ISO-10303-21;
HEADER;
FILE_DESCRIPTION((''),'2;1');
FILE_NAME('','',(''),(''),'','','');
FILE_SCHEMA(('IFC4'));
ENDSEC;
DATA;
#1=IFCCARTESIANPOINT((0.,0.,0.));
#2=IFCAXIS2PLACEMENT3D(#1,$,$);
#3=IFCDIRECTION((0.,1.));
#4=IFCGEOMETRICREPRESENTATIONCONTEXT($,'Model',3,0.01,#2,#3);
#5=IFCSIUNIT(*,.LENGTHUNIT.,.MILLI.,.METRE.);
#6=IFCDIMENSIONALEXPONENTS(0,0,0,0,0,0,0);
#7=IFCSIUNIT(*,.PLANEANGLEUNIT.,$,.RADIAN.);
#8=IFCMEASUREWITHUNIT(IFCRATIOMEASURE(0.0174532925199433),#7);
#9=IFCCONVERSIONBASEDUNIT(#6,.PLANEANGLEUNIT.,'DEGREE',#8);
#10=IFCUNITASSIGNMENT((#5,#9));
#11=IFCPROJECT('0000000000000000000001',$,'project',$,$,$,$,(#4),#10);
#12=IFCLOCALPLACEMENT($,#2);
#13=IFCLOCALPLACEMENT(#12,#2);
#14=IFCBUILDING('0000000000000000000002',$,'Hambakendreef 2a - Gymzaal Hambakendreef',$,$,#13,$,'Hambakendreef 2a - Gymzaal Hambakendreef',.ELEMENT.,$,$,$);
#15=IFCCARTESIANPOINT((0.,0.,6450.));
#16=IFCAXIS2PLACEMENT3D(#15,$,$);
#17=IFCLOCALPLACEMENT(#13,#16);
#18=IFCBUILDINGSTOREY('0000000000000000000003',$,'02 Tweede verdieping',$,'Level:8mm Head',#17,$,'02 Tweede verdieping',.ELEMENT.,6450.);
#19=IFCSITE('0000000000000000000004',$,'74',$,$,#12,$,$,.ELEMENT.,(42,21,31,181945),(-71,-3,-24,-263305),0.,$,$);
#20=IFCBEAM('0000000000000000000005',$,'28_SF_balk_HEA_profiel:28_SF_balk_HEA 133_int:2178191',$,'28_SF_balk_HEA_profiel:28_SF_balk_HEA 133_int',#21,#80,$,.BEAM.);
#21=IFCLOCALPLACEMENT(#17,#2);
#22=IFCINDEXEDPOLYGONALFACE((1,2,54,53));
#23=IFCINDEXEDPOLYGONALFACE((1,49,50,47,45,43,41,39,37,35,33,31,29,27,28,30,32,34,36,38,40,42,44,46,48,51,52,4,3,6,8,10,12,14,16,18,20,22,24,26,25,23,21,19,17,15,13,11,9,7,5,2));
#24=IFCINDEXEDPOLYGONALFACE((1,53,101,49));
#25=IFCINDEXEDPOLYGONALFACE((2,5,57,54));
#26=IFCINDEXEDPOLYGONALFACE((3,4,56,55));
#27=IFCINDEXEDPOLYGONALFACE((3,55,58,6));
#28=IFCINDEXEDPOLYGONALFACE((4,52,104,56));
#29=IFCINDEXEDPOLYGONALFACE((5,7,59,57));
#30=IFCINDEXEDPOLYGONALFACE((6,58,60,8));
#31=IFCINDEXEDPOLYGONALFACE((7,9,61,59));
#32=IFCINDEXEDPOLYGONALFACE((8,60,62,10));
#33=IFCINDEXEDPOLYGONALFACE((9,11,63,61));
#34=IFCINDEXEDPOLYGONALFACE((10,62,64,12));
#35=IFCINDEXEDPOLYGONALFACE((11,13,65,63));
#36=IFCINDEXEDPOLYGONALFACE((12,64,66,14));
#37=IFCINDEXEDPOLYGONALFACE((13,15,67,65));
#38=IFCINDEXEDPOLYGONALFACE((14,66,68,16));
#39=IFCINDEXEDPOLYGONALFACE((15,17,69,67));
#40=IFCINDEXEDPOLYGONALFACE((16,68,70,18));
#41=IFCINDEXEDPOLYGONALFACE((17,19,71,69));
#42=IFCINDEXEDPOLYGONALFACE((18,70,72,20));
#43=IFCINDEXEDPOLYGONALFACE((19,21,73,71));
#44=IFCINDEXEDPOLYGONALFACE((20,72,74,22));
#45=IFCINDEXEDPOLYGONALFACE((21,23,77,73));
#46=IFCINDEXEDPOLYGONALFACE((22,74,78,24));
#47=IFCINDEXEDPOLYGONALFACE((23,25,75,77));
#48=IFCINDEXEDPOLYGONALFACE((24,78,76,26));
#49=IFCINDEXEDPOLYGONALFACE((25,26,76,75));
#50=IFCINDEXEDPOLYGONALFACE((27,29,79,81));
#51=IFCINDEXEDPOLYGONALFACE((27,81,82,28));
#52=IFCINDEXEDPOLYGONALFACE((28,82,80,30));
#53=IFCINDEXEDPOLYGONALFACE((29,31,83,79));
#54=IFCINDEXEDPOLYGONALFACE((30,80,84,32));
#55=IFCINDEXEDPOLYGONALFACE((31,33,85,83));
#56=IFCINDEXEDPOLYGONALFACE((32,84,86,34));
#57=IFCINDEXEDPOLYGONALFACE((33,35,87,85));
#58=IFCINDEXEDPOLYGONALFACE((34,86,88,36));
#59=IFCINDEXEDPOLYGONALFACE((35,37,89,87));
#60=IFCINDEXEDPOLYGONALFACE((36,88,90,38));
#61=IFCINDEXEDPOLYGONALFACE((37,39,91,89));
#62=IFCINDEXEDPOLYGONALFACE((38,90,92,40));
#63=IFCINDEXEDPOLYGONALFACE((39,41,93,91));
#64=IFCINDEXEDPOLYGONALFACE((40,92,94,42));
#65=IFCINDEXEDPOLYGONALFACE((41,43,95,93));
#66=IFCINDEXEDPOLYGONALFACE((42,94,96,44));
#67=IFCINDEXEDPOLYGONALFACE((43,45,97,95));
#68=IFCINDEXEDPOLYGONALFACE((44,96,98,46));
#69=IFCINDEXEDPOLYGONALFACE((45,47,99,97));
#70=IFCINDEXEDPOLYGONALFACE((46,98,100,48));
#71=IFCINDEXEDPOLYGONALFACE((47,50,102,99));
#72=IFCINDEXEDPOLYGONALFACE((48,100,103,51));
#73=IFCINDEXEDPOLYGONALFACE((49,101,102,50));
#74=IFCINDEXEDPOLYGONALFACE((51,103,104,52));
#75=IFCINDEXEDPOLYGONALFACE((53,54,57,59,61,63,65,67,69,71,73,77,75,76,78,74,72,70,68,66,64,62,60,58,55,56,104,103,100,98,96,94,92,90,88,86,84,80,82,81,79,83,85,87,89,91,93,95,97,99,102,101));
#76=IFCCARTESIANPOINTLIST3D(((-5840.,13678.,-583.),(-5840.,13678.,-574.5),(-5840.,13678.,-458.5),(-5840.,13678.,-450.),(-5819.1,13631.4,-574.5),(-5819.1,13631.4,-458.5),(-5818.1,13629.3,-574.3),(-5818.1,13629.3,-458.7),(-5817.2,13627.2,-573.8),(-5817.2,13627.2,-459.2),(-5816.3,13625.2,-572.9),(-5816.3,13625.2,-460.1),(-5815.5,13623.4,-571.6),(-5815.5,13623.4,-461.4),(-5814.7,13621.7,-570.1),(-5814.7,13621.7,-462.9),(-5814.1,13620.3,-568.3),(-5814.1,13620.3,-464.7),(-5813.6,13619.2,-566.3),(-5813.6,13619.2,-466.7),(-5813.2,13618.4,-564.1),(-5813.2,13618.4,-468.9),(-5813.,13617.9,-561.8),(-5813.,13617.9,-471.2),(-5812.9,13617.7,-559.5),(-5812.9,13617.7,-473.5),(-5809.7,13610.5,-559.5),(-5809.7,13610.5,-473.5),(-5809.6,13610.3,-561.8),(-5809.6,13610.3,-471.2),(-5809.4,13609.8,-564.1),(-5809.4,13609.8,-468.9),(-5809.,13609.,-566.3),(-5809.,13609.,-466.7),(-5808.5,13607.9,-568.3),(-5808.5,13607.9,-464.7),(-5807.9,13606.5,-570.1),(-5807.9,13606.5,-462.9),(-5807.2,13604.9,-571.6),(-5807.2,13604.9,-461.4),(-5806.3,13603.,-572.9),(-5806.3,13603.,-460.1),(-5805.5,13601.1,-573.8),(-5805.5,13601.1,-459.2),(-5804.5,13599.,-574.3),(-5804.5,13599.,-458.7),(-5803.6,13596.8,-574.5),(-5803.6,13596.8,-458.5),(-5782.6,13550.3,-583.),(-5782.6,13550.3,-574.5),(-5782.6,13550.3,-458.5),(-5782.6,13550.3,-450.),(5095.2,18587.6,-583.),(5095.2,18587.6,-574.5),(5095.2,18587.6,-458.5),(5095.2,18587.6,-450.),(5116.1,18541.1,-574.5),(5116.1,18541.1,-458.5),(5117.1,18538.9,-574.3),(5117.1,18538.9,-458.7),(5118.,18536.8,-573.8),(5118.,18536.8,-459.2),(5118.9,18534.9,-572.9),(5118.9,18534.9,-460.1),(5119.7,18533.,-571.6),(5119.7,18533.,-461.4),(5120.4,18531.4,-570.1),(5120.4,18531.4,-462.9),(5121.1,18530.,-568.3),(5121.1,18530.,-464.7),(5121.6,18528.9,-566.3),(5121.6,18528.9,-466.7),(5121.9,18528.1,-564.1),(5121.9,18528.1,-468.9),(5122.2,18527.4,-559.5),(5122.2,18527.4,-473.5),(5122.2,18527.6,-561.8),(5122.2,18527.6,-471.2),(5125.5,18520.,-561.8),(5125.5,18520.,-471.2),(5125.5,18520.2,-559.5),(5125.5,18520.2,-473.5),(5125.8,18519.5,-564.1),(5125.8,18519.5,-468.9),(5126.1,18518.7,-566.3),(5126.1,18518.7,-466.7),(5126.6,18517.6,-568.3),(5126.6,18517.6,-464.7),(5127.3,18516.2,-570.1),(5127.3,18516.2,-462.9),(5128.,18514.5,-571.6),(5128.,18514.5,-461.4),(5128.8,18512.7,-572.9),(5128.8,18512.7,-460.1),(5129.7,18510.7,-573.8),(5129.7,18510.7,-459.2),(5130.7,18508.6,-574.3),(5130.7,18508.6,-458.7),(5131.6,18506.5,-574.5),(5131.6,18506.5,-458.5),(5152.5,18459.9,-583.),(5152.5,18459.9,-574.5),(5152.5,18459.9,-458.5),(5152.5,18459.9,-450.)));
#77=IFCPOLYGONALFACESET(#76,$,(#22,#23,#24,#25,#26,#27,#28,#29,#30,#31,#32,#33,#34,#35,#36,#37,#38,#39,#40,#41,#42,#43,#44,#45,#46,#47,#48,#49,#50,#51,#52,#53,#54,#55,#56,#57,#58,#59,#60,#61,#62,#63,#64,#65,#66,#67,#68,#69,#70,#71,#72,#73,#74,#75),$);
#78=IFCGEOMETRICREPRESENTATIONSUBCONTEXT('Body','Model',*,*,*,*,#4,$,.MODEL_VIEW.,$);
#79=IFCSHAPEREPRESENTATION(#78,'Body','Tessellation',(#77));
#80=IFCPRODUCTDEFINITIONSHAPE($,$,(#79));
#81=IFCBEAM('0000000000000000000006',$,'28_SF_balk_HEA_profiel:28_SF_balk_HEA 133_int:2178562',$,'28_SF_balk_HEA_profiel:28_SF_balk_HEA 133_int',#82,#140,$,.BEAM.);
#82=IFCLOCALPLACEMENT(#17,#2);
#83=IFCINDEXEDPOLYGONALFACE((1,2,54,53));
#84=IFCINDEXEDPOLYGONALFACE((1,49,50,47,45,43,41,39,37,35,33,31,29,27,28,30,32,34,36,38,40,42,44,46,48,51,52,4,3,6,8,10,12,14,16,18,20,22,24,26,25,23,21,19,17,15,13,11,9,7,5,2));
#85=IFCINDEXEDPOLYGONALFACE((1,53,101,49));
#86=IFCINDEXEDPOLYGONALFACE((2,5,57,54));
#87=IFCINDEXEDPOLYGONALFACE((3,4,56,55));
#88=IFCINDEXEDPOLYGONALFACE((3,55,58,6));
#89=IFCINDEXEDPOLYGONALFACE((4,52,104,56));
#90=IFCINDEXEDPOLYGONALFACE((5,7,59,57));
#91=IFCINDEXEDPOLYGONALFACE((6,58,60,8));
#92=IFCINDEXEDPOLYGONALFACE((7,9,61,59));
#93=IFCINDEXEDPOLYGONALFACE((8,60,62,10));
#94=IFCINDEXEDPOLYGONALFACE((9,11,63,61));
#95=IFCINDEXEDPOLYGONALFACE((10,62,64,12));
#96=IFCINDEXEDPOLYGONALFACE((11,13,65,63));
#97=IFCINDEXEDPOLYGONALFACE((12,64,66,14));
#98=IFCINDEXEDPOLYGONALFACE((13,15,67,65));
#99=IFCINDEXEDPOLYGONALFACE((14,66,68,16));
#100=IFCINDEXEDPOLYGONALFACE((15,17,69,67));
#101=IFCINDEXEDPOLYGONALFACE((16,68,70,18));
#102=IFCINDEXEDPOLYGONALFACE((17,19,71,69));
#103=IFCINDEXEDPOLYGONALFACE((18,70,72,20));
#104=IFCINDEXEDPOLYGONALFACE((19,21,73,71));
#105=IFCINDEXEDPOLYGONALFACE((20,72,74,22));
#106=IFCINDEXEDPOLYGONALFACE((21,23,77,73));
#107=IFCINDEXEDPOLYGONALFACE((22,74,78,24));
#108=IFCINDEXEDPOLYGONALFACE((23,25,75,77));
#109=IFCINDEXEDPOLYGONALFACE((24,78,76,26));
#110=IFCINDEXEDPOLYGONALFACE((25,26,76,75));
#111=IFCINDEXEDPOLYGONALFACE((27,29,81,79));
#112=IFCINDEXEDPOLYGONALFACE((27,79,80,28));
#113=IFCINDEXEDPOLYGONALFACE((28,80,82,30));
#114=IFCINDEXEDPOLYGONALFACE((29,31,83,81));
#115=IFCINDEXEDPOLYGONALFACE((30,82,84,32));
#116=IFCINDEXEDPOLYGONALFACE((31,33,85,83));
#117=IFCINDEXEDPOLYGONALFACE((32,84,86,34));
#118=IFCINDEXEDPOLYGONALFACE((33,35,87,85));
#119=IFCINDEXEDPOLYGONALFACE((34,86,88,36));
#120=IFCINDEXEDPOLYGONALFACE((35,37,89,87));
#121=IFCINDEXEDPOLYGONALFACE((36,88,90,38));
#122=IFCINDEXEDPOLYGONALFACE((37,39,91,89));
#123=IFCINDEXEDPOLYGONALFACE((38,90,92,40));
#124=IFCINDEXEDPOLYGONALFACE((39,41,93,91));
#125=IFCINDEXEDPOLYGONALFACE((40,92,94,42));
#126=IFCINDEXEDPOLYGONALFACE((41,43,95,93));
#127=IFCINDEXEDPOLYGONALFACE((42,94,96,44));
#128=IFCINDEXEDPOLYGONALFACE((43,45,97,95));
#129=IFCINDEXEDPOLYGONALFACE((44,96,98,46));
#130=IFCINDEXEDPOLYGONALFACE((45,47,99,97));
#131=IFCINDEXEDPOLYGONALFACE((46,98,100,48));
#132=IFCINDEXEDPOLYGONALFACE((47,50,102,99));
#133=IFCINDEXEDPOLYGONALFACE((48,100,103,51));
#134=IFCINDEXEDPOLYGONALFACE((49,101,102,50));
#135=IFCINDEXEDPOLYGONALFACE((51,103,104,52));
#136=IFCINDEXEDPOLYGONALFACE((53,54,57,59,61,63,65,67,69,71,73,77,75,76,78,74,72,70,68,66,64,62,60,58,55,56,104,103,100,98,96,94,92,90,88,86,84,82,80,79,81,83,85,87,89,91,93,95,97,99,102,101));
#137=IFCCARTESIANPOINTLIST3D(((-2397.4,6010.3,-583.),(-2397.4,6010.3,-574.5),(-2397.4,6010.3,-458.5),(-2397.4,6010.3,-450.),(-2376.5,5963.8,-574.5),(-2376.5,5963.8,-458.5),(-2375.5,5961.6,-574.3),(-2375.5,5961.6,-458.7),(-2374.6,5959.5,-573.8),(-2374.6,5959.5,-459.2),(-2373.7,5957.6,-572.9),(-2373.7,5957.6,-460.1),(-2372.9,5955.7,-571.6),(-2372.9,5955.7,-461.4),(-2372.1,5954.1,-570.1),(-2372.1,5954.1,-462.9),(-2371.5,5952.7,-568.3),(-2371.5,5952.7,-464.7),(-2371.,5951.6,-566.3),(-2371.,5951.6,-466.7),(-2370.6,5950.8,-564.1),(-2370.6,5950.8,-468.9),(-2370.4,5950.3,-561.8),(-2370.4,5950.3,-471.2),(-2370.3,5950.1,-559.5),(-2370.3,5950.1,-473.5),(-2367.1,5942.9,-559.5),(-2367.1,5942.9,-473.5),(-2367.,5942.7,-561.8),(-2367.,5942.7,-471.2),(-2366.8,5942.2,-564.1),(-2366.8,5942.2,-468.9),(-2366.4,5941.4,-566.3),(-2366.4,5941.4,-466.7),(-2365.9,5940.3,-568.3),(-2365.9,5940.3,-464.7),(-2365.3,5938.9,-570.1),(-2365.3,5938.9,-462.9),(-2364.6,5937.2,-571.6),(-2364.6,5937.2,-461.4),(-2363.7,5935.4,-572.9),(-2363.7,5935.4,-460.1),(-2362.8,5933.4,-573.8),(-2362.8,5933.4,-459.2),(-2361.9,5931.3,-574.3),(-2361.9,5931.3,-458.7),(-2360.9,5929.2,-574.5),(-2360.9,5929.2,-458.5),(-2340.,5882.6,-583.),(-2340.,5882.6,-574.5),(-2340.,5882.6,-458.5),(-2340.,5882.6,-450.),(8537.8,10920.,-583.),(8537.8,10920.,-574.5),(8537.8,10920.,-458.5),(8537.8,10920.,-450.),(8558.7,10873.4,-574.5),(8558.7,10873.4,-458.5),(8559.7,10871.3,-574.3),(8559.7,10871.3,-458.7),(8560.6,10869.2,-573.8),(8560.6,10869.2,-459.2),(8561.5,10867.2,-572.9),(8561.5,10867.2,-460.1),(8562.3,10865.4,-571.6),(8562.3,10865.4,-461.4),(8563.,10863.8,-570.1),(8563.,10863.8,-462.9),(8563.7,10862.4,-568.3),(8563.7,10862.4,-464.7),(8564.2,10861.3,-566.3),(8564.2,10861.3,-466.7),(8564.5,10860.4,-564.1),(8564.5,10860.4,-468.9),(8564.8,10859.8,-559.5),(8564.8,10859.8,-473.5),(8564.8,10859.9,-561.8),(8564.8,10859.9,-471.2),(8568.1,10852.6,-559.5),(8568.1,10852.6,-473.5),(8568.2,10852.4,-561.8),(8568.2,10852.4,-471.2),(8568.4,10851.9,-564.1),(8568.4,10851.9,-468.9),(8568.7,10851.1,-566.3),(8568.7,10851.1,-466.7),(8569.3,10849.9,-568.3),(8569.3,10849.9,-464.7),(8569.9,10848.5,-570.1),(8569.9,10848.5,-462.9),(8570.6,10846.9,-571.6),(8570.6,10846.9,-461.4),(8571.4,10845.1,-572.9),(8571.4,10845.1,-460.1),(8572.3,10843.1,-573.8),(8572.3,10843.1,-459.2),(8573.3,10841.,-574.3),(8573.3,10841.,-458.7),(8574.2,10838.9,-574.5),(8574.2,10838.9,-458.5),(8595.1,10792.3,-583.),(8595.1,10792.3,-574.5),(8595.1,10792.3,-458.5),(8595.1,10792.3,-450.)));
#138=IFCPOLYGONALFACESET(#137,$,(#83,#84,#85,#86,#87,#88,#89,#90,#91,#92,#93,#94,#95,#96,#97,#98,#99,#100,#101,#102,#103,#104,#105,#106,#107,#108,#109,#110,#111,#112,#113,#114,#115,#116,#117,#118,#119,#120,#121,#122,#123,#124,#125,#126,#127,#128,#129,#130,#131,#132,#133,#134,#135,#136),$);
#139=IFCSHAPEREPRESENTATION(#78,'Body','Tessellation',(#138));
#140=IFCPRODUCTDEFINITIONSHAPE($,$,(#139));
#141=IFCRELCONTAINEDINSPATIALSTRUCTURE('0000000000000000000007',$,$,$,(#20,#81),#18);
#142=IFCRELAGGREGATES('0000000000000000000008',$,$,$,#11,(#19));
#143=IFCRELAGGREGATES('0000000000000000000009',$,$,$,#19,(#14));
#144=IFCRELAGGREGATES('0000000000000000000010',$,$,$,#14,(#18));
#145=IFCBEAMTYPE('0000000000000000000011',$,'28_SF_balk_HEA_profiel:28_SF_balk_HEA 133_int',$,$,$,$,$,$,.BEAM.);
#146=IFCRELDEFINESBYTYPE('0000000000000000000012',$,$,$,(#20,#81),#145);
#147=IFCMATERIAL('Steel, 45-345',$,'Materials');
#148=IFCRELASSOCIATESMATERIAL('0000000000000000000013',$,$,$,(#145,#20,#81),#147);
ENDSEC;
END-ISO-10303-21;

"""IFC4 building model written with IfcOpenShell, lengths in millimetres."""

from ifc_helpers import new_model, entity, si_unit, converted_unit, direction, frame, origin, place, context, subcontext, project, spatial, indexed_curve, outline, extrude, source, transform, mapped, material, type_object, type_shapes, element, save


model = new_model("IFC4")

# Units and contexts
model_context = context("Model", 3, precision=0.01, world=origin(), true_north=direction((0.0, 1.0)))
body_context = subcontext(model_context, "Body", "Model", "MODEL_VIEW")
ifc_project = project(units=[si_unit("LENGTHUNIT", "METRE", prefix="MILLI"), converted_unit("PLANEANGLEUNIT", "DEGREE", entity("IfcRatioMeasure", 0.0174532925199433), si_unit("PLANEANGLEUNIT", "RADIAN"), dimensions=[0, 0, 0, 0, 0, 0, 0])], contexts=[model_context])

# Site, building, storey
site_placement = place(None, origin())
site = spatial("IfcSite", under=ifc_project, at=site_placement, Name="74", CompositionType="ELEMENT", RefLatitude=(42, 21, 31, 181945), RefLongitude=(-71, -3, -24, -263305), RefElevation=0.0)
building_placement = place(site_placement, origin())
building = spatial("IfcBuilding", under=site, at=building_placement, Name="Hambakendreef 2a - Gymzaal Hambakendreef", LongName="Hambakendreef 2a - Gymzaal Hambakendreef", CompositionType="ELEMENT")
storey_placement = place(building_placement, frame((0.0, 0.0, 6450.0)))
storey = spatial("IfcBuildingStorey", under=building, at=storey_placement, Name="02 Tweede verdieping", ObjectType="Level:8mm Head", LongName="02 Tweede verdieping", CompositionType="ELEMENT", Elevation=6450.0)

# Beams
ifc_material_1 = material(Name="Steel, 45-345", Category="Materials")
beam_type = type_object("IfcBeamType", Name="28_SF_balk_HEA_profiel:28_SF_balk_HEA 133_int", PredefinedType="BEAM", material=ifc_material_1)
shared_shape = source(origin(), body_context, "Body", "SweptSolid", [
    extrude(outline(indexed_curve([(-66.5, -70.0), (-58.0, -70.0), (-58.0, -18.9), (-57.8, -16.6), (-57.3, -14.3), (-56.4, -12.1), (-55.1, -10.1), (-53.6, -8.3), (-51.8, -6.8), (-49.8, -5.6), (-47.6, -4.7), (-45.3, -4.1), (-43.0, -3.9), (43.0, -3.9), (45.3, -4.1), (47.6, -4.7), (49.8, -5.6), (51.8, -6.8), (53.6, -8.3), (55.1, -10.1), (56.4, -12.1), (57.3, -14.3), (57.8, -16.6), (58.0, -18.9), (58.0, -70.0), (66.5, -70.0), (66.5, 70.0), (58.0, 70.0), (58.0, 19.0), (57.8, 16.6), (57.3, 14.3), (56.4, 12.1), (55.1, 10.1), (53.6, 8.3), (51.8, 6.8), (49.8, 5.6), (47.6, 4.7), (45.3, 4.1), (43.0, 4.0), (-43.0, 4.0), (-45.3, 4.1), (-47.6, 4.7), (-49.8, 5.6), (-51.8, 6.8), (-53.6, 8.3), (-55.1, 10.1), (-56.4, 12.1), (-57.3, 14.3), (-57.8, 16.6), (-58.0, 18.9), (-58.0, 70.0), (-66.5, 70.0), (-66.5, -70.0)], self_intersect=False)), frame((-4928.5, 0.0, 0.0), z_axis=(1.0, 0.0, 0.0), x_axis=(0.0, 0.0, -1.0)), (0.0, 0.0, 1.0), 11986.8),
])
type_shapes(beam_type, [shared_shape])
for number, where, z_axis, x_axis, name in (
    (1, (-1315.2, 15632.8, -516.5), (0.0, 0.0, 1.0), (0.91227, 0.40959, 0.0), "28_SF_balk_HEA_profiel:28_SF_balk_HEA 133_int:2178191"),
    (2, (2127.4, 7965.1, -516.5), (0.0, 0.0, 1.0), (0.91227, 0.40959, 0.0), "28_SF_balk_HEA_profiel:28_SF_balk_HEA 133_int:2178562"),
):
    element("IfcBeam", number, at=place(storey_placement, frame(where, z_axis=z_axis, x_axis=x_axis)), inside=storey, type_object=beam_type, material=ifc_material_1, Name=name, ObjectType="28_SF_balk_HEA_profiel:28_SF_balk_HEA 133_int", PredefinedType="BEAM", context=body_context, shape_type="MappedRepresentation", body=[
        mapped(shared_shape, transform((0.0, 0.0, 0.0), scale=1.0)),
    ])

save(model, "model.ifc")
